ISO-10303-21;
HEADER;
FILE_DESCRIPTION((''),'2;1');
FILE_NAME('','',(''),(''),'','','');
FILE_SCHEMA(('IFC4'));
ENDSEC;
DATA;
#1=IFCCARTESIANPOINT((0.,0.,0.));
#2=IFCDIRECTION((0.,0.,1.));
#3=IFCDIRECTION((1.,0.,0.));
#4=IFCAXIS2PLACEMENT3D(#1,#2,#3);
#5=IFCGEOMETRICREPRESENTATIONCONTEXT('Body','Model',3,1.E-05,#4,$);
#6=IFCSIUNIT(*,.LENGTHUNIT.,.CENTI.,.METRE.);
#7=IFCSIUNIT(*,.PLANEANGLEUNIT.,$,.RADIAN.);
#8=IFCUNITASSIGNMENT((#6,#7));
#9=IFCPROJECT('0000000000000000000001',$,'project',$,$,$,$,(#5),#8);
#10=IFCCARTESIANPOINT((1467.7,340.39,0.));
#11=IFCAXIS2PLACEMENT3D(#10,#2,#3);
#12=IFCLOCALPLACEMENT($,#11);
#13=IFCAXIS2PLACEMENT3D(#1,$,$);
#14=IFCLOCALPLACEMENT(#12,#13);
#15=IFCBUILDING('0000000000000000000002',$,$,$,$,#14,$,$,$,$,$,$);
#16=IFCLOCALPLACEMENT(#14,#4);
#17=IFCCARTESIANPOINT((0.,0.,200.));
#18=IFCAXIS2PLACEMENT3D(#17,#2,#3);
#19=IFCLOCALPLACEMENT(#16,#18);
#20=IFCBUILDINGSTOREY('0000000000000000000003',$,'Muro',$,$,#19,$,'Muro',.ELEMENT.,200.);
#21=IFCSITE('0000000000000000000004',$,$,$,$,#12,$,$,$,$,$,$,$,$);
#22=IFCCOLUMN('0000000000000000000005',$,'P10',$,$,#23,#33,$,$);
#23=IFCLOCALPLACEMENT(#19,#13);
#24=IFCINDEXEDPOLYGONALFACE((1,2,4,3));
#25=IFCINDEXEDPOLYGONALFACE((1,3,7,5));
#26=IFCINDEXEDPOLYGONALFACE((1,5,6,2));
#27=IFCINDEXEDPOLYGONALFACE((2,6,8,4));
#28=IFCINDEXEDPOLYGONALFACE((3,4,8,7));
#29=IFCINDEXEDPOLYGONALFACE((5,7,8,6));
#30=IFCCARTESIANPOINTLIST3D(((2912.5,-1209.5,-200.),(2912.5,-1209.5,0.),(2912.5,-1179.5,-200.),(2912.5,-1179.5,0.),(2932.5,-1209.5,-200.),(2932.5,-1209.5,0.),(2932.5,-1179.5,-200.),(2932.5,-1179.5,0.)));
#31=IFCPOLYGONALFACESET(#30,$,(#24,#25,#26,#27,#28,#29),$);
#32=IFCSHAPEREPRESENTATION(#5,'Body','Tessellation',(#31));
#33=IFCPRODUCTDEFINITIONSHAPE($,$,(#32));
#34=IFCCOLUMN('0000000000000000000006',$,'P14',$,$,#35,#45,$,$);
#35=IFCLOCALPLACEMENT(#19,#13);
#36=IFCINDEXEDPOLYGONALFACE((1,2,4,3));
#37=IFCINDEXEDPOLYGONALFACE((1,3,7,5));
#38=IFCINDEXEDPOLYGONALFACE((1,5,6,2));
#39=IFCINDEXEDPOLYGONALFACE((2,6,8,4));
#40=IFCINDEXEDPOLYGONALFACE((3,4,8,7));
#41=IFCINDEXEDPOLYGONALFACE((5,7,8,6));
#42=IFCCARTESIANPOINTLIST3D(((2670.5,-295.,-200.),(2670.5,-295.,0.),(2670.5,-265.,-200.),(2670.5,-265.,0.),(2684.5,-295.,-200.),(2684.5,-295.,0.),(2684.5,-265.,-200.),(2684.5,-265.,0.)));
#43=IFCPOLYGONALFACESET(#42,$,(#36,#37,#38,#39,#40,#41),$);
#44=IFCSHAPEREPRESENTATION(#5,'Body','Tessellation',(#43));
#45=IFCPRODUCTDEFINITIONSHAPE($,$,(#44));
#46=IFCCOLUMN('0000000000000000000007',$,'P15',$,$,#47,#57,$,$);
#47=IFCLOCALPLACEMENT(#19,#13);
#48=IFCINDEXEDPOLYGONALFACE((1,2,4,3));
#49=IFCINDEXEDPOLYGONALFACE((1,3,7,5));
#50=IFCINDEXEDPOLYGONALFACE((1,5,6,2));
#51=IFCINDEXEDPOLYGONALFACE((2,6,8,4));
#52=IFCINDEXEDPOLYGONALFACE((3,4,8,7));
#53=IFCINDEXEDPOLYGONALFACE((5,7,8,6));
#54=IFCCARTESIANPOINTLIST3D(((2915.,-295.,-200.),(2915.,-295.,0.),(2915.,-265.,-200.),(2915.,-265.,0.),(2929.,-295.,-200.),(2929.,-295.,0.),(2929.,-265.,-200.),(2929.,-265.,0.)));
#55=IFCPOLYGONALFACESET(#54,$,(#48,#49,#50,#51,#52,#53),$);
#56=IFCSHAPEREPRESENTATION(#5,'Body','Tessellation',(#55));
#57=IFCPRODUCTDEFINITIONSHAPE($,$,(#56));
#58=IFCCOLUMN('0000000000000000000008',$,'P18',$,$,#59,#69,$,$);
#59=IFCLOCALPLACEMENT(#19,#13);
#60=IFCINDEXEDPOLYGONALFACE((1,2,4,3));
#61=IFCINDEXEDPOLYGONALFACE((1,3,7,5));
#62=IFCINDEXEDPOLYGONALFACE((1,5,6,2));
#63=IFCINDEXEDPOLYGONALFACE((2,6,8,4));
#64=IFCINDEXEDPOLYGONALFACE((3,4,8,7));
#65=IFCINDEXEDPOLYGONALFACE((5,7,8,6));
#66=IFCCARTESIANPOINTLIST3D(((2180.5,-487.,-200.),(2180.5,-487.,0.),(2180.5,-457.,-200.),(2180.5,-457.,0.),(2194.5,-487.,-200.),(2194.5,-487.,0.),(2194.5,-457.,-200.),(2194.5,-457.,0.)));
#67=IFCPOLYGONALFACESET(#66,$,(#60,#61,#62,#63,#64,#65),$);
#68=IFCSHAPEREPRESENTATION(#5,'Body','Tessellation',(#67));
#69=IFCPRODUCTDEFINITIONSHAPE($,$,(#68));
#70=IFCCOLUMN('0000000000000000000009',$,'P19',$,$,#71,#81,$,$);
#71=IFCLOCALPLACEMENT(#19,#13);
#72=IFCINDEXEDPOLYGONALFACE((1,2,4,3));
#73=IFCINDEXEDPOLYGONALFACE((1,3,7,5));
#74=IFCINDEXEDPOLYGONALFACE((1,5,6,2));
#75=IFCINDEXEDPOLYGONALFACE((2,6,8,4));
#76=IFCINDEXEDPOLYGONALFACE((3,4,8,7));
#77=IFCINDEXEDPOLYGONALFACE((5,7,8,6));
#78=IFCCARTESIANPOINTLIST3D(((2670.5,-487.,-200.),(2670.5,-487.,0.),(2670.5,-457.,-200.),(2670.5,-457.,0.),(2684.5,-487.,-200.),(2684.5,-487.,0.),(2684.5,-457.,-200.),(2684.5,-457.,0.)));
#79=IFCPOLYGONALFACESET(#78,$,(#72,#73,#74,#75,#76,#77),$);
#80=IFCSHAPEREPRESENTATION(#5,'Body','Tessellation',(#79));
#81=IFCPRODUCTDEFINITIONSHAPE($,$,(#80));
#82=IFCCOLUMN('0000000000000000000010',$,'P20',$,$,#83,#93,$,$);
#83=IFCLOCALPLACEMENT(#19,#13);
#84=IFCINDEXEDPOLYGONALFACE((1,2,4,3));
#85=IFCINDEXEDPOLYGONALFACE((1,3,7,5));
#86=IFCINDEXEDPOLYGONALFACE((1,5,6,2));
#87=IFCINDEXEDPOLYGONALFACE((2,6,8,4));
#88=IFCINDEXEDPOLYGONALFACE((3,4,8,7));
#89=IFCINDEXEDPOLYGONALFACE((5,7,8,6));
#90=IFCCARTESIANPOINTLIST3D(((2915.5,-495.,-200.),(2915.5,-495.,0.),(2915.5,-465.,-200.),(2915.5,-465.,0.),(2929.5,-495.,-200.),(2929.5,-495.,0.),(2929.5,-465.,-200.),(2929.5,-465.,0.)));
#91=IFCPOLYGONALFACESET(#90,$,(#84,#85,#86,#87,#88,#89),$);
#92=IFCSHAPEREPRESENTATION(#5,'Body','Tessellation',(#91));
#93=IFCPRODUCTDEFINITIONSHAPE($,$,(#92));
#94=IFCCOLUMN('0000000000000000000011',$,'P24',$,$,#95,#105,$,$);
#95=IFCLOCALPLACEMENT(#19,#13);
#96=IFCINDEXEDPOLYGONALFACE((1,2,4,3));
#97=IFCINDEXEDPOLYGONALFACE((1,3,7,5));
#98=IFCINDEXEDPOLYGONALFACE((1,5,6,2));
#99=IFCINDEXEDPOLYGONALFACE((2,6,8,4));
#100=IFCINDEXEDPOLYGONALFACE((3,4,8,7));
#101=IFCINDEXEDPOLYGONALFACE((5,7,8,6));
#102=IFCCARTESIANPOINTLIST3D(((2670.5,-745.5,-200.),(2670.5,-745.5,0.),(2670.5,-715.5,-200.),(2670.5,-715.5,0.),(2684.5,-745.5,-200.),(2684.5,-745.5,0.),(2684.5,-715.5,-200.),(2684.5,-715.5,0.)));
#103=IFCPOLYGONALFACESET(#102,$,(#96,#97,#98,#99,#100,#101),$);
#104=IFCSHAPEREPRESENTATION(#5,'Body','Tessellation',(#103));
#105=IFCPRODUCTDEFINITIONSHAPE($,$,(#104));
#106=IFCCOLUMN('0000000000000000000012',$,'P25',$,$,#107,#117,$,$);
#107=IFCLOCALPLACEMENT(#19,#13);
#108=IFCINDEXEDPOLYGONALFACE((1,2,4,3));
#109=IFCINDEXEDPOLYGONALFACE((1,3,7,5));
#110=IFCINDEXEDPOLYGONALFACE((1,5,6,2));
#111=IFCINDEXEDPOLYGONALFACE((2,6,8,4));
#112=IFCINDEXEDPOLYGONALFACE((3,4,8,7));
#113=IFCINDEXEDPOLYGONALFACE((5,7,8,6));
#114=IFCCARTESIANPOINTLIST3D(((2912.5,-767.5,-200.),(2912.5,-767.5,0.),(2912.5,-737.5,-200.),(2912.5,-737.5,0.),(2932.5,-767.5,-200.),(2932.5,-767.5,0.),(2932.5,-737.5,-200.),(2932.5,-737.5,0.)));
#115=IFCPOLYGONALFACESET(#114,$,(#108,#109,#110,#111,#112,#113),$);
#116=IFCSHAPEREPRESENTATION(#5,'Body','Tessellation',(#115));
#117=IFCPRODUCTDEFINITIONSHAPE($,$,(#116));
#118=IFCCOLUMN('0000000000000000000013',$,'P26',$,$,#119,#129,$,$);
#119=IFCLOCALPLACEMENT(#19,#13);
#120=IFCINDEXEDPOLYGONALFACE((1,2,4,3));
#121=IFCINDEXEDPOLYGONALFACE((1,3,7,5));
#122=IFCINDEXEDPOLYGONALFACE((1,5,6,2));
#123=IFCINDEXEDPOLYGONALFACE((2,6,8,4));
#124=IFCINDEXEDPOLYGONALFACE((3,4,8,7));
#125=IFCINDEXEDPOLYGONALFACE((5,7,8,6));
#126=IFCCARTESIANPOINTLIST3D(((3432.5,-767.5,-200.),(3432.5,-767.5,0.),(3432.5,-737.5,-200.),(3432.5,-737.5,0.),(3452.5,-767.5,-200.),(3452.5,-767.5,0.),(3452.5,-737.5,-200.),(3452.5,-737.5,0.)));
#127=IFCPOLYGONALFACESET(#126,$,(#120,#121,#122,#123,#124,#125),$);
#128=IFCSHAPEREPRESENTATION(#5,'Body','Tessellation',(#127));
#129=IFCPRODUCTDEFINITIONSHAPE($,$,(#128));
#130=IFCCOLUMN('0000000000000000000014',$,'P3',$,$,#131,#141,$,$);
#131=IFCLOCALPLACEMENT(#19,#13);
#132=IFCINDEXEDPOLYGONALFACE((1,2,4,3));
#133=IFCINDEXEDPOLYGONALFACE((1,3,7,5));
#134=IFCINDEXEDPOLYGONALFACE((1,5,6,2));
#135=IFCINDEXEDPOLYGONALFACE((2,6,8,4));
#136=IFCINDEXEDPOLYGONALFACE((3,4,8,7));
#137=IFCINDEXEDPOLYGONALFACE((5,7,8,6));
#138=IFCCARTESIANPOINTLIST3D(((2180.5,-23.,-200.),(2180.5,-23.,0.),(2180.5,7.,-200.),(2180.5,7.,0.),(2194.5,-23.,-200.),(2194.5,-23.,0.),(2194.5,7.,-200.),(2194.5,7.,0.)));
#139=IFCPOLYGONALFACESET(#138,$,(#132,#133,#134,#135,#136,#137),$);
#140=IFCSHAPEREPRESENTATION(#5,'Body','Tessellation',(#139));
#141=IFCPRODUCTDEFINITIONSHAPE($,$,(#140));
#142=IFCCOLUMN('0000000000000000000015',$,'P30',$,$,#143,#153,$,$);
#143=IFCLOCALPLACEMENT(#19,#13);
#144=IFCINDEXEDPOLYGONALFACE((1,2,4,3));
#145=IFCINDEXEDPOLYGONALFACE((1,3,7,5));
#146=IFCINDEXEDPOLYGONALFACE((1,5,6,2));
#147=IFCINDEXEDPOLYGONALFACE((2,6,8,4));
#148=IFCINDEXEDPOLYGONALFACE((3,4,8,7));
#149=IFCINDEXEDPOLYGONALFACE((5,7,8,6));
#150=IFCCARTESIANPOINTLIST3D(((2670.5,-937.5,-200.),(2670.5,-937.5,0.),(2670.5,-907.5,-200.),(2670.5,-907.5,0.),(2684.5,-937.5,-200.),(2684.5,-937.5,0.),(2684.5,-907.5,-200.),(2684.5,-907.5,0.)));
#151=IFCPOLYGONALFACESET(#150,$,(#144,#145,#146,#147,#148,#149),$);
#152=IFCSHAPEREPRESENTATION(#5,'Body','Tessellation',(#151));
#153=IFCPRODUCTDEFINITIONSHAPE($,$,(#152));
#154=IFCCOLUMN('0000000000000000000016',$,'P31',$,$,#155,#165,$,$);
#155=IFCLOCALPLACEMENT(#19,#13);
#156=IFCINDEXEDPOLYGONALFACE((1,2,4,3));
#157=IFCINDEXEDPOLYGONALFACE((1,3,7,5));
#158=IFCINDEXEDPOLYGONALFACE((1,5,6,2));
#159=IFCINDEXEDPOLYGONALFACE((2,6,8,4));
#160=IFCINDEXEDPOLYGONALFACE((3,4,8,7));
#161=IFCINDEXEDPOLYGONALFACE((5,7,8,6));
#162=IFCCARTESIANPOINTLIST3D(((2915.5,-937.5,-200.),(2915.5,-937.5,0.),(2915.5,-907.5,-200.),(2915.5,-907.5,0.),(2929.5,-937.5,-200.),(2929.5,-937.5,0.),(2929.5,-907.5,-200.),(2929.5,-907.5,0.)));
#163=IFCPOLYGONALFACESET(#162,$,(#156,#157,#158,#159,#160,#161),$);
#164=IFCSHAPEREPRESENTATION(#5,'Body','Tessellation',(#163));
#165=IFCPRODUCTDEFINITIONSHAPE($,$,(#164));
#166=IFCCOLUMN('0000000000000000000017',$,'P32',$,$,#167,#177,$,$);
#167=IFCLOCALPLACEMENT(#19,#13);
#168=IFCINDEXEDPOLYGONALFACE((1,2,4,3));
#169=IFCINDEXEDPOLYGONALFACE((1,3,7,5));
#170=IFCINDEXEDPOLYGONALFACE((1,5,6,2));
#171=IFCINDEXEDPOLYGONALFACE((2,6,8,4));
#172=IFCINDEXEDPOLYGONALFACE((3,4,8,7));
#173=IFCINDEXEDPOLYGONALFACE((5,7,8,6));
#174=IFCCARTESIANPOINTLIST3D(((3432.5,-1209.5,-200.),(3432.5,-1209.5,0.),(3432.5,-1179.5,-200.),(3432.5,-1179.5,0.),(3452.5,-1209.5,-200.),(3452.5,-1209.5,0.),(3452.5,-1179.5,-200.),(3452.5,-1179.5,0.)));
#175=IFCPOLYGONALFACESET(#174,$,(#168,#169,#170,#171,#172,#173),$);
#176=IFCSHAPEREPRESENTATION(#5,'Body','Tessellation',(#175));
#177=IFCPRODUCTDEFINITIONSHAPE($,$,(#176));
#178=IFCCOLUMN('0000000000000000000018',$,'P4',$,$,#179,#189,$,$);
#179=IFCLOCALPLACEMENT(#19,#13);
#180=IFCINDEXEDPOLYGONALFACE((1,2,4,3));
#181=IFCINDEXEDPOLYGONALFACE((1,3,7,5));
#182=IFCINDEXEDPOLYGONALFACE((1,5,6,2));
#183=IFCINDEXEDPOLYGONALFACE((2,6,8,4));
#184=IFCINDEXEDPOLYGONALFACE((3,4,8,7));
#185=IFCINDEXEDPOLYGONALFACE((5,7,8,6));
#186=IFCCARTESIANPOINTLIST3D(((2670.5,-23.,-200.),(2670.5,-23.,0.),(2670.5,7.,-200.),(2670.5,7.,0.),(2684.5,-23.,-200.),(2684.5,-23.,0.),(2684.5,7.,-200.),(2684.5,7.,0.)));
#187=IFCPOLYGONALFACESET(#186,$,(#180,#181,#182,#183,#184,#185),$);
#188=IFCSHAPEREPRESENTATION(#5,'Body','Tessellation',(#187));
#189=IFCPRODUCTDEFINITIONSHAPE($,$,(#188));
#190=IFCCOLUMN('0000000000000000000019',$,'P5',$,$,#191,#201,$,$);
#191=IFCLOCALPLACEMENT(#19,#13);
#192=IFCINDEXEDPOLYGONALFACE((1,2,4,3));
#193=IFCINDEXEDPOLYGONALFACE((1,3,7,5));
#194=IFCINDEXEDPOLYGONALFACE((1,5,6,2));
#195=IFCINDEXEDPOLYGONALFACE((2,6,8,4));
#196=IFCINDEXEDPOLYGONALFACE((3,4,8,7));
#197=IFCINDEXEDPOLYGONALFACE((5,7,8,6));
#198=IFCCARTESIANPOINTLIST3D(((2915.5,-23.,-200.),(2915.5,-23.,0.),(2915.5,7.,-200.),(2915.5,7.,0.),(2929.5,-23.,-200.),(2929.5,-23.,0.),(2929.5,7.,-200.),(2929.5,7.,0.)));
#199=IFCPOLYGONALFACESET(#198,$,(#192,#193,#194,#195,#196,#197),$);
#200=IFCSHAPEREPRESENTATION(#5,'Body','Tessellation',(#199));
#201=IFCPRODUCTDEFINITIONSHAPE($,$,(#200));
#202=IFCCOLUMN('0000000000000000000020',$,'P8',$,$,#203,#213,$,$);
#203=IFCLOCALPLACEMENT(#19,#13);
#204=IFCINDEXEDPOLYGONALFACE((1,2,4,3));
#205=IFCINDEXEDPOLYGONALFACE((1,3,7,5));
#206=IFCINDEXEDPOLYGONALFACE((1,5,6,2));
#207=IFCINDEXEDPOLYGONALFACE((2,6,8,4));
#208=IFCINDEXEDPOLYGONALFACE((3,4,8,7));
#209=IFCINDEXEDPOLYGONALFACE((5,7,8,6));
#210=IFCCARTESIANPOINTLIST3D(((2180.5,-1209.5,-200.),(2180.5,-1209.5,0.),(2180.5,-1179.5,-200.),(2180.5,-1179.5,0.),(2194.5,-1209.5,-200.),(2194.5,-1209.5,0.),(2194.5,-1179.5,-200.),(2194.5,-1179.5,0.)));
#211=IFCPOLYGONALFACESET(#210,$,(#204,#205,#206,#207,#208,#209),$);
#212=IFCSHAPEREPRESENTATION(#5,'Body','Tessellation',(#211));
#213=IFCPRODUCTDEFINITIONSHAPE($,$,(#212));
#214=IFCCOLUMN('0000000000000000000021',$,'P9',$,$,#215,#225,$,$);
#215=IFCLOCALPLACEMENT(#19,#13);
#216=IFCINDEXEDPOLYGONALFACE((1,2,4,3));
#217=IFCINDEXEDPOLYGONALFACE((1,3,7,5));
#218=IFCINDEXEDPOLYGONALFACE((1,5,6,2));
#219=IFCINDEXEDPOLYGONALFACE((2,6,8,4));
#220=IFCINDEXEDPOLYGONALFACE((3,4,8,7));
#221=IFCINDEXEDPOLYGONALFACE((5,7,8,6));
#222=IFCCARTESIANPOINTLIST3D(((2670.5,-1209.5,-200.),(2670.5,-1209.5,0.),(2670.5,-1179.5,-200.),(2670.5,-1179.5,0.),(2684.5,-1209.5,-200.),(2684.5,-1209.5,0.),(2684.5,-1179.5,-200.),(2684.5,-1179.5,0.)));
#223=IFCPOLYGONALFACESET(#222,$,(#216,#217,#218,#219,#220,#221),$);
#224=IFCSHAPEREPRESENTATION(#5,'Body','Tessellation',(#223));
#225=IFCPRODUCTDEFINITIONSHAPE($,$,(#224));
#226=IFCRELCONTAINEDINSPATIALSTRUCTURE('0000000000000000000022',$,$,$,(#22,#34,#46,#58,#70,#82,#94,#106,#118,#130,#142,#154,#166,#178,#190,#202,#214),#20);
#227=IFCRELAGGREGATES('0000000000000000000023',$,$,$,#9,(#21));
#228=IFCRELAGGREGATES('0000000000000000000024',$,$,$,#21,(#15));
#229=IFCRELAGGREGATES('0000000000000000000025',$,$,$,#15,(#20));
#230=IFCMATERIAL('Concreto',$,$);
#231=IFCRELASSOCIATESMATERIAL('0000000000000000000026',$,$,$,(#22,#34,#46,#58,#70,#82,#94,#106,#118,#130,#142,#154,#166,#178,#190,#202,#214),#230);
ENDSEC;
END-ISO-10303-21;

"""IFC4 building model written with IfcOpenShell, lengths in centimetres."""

from ifc_helpers import new_model, si_unit, frame, origin, origin_with_axes, origin_2d_with_axis, place, context, project, spatial, rectangle, extrude, material, element, save


model = new_model("IFC4")

# Units and contexts
model_context = context("Model", 3, precision=1e-05, world=origin_with_axes(), identifier="Body")
ifc_project = project(units=[si_unit("LENGTHUNIT", "METRE", prefix="CENTI"), si_unit("PLANEANGLEUNIT", "RADIAN")], contexts=[model_context])

# Site, building, storey
site_placement = place(None, frame((1467.7, 340.39, 0.0), z_axis=(0.0, 0.0, 1.0), x_axis=(1.0, 0.0, 0.0)))
site = spatial("IfcSite", under=ifc_project, at=site_placement)
building_placement = place(site_placement, origin())
building = spatial("IfcBuilding", under=site, at=building_placement)
placement = place(building_placement, origin_with_axes())
storey_placement = place(placement, frame((0.0, 0.0, 200.0), z_axis=(0.0, 0.0, 1.0), x_axis=(1.0, 0.0, 0.0)))
storey = spatial("IfcBuildingStorey", under=building, at=storey_placement, Name="Muro", LongName="Muro", CompositionType="ELEMENT", Elevation=200.0)

# Columns
ifc_material = material(Name="Concreto")
column_1_placement = place(storey_placement, frame((2922.5, -1194.5, 0.0), z_axis=(0.0, 0.0, 1.0), x_axis=(1.0, 0.0, 0.0)))
element("IfcColumn", 1, at=column_1_placement, inside=storey, material=ifc_material, Name="P10", context=model_context, shape_type="SolidModel", body=[
    extrude(rectangle(XDim=20.0, YDim=30.0, at=origin_2d_with_axis()), origin_with_axes(), (0.0, 0.0, -1.0), 200.0),
])
for number, where, z_axis, x_axis, name in (
    (2, (2677.5, -280.0, 0.0), (0.0, 0.0, 1.0), (1.0, 0.0, 0.0), "P14"),
    (3, (2922.0, -280.0, 0.0), (0.0, 0.0, 1.0), (1.0, 0.0, 0.0), "P15"),
):
    element("IfcColumn", number, at=place(storey_placement, frame(where, z_axis=z_axis, x_axis=x_axis)), inside=storey, material=ifc_material, Name=name, context=model_context, shape_type="SolidModel", body=[
        extrude(rectangle(XDim=14.0, YDim=30.0, at=origin_2d_with_axis()), origin_with_axes(), (0.0, 0.0, -1.0), 200.0),
    ])
for number, where, z_axis, x_axis, name in (
    (4, (2187.5, -472.0, 0.0), (0.0, 0.0, 1.0), (1.0, 0.0, 0.0), "P18"),
    (5, (2677.5, -472.0, 0.0), (0.0, 0.0, 1.0), (1.0, 0.0, 0.0), "P19"),
):
    element("IfcColumn", number, at=place(storey_placement, frame(where, z_axis=z_axis, x_axis=x_axis)), inside=storey, material=ifc_material, Name=name, context=model_context, shape_type="SolidModel", body=[
        extrude(rectangle(XDim=14.0, YDim=30.0, at=origin_2d_with_axis()), frame((0.0, 0.0, 0.0), z_axis=(0.0, 0.0, 1.0), x_axis=(-1.0, 0.0, 0.0)), (0.0, 0.0, -1.0), 200.0),
    ])
for number, where, z_axis, x_axis, name in (
    (6, (2922.5, -480.0, 0.0), (0.0, 0.0, 1.0), (1.0, 0.0, 0.0), "P20"),
    (7, (2677.5, -730.5, 0.0), (0.0, 0.0, 1.0), (1.0, 0.0, 0.0), "P24"),
):
    element("IfcColumn", number, at=place(storey_placement, frame(where, z_axis=z_axis, x_axis=x_axis)), inside=storey, material=ifc_material, Name=name, context=model_context, shape_type="SolidModel", body=[
        extrude(rectangle(XDim=14.0, YDim=30.0, at=origin_2d_with_axis()), origin_with_axes(), (0.0, 0.0, -1.0), 200.0),
    ])
column_2_placement = place(storey_placement, frame((2922.5, -752.5, 0.0), z_axis=(0.0, 0.0, 1.0), x_axis=(1.0, 0.0, 0.0)))
element("IfcColumn", 8, at=column_2_placement, inside=storey, material=ifc_material, Name="P25", context=model_context, shape_type="SolidModel", body=[
    extrude(rectangle(XDim=20.0, YDim=30.0, at=origin_2d_with_axis()), frame((0.0, 0.0, 0.0), z_axis=(0.0, 0.0, 1.0), x_axis=(-1.0, 0.0, 0.0)), (0.0, 0.0, -1.0), 200.0),
])
column_3_placement = place(storey_placement, frame((3442.5, -752.5, 0.0), z_axis=(0.0, 0.0, 1.0), x_axis=(1.0, 0.0, 0.0)))
element("IfcColumn", 9, at=column_3_placement, inside=storey, material=ifc_material, Name="P26", context=model_context, shape_type="SolidModel", body=[
    extrude(rectangle(XDim=20.0, YDim=30.0, at=origin_2d_with_axis()), origin_with_axes(), (0.0, 0.0, -1.0), 200.0),
])
for number, where, z_axis, x_axis, name in (
    (10, (2187.5, -8.0, 0.0), (0.0, 0.0, 1.0), (1.0, 0.0, 0.0), "P3"),
    (11, (2677.5, -922.5, 0.0), (0.0, 0.0, 1.0), (1.0, 0.0, 0.0), "P30"),
    (12, (2922.5, -922.5, 0.0), (0.0, 0.0, 1.0), (1.0, 0.0, 0.0), "P31"),
):
    element("IfcColumn", number, at=place(storey_placement, frame(where, z_axis=z_axis, x_axis=x_axis)), inside=storey, material=ifc_material, Name=name, context=model_context, shape_type="SolidModel", body=[
        extrude(rectangle(XDim=14.0, YDim=30.0, at=origin_2d_with_axis()), origin_with_axes(), (0.0, 0.0, -1.0), 200.0),
    ])
column_4_placement = place(storey_placement, frame((3442.5, -1194.5, 0.0), z_axis=(0.0, 0.0, 1.0), x_axis=(1.0, 0.0, 0.0)))
element("IfcColumn", 13, at=column_4_placement, inside=storey, material=ifc_material, Name="P32", context=model_context, shape_type="SolidModel", body=[
    extrude(rectangle(XDim=20.0, YDim=30.0, at=origin_2d_with_axis()), origin_with_axes(), (0.0, 0.0, -1.0), 200.0),
])
for number, where, z_axis, x_axis, name in (
    (14, (2677.5, -8.0, 0.0), (0.0, 0.0, 1.0), (1.0, 0.0, 0.0), "P4"),
    (15, (2922.5, -8.0, 0.0), (0.0, 0.0, 1.0), (1.0, 0.0, 0.0), "P5"),
    (16, (2187.5, -1194.5, 0.0), (0.0, 0.0, 1.0), (1.0, 0.0, 0.0), "P8"),
    (17, (2677.5, -1194.5, 0.0), (0.0, 0.0, 1.0), (1.0, 0.0, 0.0), "P9"),
):
    element("IfcColumn", number, at=place(storey_placement, frame(where, z_axis=z_axis, x_axis=x_axis)), inside=storey, material=ifc_material, Name=name, context=model_context, shape_type="SolidModel", body=[
        extrude(rectangle(XDim=14.0, YDim=30.0, at=origin_2d_with_axis()), origin_with_axes(), (0.0, 0.0, -1.0), 200.0),
    ])

save(model, "model.ifc")
